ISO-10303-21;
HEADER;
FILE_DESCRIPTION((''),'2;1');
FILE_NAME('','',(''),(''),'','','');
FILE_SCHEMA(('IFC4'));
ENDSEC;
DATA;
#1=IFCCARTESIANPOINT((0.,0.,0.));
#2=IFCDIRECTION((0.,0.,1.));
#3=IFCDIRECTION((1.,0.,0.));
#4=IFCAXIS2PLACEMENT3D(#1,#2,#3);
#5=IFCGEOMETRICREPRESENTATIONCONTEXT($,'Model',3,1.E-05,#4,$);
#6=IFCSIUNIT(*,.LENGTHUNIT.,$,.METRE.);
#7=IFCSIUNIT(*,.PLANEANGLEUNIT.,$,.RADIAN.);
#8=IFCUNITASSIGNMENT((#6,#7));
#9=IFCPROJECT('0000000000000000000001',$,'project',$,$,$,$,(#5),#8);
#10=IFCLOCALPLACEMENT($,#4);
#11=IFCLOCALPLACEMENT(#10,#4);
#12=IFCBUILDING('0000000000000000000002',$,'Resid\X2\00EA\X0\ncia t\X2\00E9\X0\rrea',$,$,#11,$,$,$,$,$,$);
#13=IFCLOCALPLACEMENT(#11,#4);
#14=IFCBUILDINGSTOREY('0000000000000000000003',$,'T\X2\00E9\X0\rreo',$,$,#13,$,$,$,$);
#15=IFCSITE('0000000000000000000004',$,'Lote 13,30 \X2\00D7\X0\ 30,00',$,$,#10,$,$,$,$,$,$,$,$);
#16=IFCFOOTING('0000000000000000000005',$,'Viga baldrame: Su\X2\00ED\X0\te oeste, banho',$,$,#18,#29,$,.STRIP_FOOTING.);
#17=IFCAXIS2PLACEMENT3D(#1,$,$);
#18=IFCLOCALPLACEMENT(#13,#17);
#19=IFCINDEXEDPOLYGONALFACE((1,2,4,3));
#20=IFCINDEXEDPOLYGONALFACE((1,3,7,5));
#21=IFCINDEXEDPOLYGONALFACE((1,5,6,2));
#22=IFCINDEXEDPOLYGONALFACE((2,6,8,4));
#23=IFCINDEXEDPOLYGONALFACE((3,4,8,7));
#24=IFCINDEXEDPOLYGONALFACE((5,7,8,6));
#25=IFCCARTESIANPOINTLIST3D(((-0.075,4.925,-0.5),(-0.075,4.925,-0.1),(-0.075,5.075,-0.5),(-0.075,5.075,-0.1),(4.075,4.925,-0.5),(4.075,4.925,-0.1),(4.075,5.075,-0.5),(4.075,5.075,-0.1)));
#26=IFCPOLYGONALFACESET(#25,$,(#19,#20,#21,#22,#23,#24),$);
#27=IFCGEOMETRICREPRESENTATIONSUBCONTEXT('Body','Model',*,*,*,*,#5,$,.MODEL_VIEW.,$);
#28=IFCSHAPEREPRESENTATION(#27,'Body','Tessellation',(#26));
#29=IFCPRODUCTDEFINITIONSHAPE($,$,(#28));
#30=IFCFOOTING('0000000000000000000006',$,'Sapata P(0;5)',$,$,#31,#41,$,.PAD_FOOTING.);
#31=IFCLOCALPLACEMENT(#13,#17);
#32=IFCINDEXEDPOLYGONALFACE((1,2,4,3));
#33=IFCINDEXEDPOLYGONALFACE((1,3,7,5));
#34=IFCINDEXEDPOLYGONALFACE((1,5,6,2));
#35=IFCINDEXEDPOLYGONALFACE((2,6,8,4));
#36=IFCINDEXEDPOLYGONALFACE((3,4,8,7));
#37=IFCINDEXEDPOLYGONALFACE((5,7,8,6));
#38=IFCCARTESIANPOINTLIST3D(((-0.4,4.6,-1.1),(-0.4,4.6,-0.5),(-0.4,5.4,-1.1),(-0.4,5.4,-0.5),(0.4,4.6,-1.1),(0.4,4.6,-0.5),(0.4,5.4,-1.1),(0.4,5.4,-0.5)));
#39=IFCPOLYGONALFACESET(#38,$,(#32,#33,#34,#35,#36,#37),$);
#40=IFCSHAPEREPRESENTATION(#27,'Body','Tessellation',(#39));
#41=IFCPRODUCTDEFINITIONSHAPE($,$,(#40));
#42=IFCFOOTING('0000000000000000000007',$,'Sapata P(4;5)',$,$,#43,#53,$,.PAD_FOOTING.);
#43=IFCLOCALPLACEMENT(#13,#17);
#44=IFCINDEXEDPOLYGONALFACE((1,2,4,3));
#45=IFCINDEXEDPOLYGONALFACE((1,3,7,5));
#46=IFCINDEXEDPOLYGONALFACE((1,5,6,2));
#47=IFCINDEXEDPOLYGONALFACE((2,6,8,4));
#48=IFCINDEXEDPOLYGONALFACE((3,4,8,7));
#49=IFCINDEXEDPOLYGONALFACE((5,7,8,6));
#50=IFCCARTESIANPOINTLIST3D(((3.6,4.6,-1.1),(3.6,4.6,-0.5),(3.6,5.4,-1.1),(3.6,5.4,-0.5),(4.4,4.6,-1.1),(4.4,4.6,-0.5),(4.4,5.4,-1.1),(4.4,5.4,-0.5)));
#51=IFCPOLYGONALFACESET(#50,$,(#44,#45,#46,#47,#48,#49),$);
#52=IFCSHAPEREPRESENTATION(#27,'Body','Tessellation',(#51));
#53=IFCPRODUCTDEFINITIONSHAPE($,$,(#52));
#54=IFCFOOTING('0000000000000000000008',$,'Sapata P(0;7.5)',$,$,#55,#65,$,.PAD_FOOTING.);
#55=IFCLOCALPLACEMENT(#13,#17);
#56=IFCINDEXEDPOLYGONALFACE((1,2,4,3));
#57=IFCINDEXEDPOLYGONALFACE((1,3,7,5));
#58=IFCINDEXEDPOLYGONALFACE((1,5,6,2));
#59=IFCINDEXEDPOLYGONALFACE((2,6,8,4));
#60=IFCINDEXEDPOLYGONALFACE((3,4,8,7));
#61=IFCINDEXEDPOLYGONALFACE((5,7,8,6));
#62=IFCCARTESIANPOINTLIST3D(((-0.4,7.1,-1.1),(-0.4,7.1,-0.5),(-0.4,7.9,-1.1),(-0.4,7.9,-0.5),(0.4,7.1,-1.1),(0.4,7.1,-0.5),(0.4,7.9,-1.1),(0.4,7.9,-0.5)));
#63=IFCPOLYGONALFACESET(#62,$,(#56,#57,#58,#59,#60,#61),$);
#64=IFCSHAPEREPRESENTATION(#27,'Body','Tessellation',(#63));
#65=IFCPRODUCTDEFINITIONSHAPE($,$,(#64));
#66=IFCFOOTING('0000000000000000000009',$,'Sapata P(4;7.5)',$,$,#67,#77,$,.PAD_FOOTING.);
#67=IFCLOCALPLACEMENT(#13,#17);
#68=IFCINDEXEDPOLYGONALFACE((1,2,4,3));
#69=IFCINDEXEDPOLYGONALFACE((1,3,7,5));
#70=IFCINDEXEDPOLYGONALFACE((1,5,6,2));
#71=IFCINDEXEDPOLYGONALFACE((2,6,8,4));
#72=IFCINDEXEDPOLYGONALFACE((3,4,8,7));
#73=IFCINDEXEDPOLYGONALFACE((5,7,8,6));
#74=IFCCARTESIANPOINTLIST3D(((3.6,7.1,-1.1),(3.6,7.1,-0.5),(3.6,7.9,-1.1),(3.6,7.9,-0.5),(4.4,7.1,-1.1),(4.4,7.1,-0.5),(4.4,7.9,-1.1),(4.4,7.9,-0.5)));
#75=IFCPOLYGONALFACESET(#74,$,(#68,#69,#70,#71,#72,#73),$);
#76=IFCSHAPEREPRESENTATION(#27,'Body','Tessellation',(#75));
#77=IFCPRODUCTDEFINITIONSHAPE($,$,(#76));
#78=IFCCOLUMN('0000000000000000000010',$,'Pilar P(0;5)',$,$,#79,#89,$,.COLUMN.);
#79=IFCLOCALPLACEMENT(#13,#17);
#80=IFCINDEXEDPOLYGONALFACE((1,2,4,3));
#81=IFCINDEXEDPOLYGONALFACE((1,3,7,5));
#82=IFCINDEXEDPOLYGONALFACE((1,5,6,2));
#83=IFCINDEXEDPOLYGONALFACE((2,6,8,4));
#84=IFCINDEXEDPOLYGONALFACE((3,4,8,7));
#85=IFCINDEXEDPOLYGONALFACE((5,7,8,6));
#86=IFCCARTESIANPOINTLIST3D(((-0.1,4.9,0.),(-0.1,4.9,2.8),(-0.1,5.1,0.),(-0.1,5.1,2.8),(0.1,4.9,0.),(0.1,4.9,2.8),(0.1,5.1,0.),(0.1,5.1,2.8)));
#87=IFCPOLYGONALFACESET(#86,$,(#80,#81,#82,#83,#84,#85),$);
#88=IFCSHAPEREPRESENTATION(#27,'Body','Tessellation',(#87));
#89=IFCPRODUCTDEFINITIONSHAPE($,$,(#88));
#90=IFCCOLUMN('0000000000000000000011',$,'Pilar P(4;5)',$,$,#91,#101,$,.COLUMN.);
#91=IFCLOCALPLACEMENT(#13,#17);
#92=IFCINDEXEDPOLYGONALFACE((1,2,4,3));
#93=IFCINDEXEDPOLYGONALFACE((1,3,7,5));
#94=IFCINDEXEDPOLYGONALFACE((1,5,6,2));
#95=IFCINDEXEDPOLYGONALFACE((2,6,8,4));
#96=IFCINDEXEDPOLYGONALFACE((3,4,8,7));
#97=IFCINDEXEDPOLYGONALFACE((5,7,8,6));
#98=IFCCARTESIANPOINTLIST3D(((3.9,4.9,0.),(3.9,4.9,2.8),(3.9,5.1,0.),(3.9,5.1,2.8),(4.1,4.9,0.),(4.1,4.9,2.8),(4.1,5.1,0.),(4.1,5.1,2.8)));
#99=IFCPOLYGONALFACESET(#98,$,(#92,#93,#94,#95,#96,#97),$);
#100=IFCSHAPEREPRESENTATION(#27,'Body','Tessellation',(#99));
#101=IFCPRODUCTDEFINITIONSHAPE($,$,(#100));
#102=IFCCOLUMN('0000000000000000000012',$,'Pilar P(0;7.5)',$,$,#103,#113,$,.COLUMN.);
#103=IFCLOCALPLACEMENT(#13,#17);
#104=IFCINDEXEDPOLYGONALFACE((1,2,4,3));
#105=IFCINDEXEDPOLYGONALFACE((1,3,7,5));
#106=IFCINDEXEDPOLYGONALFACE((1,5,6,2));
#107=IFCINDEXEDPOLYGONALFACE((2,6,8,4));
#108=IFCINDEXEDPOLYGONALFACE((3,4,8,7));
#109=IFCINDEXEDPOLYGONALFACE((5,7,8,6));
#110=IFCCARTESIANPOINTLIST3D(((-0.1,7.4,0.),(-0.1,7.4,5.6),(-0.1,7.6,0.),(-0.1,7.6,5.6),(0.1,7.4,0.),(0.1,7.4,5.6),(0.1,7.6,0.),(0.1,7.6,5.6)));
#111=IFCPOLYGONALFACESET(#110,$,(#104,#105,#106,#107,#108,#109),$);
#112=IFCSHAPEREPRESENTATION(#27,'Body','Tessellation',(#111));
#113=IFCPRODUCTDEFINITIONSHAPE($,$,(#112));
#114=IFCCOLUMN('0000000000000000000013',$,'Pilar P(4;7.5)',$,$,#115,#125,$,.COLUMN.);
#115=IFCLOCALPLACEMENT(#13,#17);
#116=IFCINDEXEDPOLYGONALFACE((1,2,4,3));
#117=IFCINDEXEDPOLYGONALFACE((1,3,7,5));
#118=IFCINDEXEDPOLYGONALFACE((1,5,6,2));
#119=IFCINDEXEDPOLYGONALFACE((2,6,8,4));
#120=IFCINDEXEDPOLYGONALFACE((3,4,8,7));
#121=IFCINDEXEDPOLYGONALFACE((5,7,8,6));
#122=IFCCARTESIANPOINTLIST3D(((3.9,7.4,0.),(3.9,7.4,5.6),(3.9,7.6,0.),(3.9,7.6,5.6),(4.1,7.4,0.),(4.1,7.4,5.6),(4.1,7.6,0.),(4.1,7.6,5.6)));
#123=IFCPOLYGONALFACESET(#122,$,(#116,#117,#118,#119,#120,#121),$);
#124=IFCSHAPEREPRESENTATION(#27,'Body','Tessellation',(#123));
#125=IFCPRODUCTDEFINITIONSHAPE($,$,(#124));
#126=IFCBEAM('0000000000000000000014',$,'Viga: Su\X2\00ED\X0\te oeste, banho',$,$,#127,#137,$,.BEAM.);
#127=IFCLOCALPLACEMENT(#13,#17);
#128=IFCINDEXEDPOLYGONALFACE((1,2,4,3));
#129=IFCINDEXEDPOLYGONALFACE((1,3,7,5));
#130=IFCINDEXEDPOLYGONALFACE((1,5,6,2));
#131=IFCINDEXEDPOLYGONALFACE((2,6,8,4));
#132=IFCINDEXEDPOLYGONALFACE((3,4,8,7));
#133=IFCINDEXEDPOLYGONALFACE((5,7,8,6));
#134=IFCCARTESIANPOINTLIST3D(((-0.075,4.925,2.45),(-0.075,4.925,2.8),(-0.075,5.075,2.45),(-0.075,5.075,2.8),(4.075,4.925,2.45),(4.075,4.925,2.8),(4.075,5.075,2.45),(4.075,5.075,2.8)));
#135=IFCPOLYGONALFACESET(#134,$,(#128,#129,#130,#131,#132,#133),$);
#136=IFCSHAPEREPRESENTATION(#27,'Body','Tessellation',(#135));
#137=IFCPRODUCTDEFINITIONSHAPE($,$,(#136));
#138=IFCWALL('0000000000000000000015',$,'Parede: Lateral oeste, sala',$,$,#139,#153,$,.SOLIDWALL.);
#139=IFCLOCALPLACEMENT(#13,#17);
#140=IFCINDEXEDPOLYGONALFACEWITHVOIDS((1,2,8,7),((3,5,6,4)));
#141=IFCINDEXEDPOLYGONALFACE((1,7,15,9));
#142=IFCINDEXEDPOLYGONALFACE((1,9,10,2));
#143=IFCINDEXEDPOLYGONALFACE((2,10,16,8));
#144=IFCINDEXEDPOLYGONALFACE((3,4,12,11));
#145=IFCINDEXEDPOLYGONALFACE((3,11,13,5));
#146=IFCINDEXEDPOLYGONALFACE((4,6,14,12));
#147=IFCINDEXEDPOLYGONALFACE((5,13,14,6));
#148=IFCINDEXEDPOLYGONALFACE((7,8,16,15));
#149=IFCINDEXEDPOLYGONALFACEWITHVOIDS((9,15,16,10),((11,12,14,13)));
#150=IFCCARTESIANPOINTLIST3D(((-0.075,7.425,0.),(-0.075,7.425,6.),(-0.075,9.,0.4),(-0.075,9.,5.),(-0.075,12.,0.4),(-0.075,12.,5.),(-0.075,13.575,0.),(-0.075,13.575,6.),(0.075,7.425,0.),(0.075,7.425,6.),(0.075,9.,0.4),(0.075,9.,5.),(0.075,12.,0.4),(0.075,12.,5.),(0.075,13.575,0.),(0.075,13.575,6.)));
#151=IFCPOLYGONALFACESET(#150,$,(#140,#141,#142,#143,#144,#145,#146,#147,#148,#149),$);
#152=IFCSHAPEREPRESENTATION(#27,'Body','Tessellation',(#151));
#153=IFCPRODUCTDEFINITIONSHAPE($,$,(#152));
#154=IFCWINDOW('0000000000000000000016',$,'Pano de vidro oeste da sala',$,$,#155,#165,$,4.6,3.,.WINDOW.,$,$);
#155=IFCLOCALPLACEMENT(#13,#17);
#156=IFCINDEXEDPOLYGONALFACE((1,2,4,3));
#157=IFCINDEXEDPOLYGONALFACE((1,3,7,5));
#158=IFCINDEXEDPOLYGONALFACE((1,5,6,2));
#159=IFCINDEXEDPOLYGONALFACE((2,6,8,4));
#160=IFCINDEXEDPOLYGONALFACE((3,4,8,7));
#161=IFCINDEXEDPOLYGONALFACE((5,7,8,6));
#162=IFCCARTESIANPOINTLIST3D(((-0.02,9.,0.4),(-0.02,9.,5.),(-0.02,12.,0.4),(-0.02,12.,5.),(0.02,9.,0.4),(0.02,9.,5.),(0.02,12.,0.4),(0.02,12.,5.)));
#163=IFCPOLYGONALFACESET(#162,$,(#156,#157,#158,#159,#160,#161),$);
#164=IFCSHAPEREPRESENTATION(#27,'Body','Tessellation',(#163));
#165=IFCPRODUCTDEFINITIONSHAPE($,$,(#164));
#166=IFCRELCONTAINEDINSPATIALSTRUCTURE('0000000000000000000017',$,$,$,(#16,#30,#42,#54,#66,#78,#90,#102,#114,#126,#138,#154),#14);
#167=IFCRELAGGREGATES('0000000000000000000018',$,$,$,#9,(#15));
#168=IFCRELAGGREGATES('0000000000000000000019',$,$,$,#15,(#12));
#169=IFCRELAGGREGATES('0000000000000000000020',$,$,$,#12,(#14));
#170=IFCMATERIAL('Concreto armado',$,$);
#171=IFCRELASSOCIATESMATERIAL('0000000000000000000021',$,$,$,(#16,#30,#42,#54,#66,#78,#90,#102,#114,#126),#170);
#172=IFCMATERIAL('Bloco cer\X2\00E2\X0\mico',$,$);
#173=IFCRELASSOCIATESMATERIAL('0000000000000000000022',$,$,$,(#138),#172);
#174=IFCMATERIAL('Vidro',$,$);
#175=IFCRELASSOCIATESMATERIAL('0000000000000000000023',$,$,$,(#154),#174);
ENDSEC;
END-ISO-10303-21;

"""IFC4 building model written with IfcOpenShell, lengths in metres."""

from ifc_helpers import new_model, si_unit, frame, origin_with_axes, place, context, subcontext, project, spatial, line, indexed_curve, outline, extrude, material, element, fill, save


model = new_model("IFC4")

# Units and contexts
model_context = context("Model", 3, precision=1e-05, world=origin_with_axes())
body_context = subcontext(model_context, "Body", "Model", "MODEL_VIEW")
ifc_project = project(units=[si_unit("LENGTHUNIT", "METRE"), si_unit("PLANEANGLEUNIT", "RADIAN")], contexts=[model_context])

# Site, building, storey
site_placement = place(None, origin_with_axes())
site = spatial("IfcSite", under=ifc_project, at=site_placement, Name="Lote 13,30 × 30,00")
building_placement = place(site_placement, origin_with_axes())
building = spatial("IfcBuilding", under=site, at=building_placement, Name="Residência térrea")
storey_placement = place(building_placement, origin_with_axes())
storey = spatial("IfcBuildingStorey", under=building, at=storey_placement, Name="Térreo")

# Footings
ifc_material_1 = material(Name="Concreto armado")
footing_1_placement = place(storey_placement, frame((-0.075, 4.925, -0.5), z_axis=(0.0, 0.0, 1.0), x_axis=(1.0, 0.0, 0.0)))
element("IfcFooting", 1, at=footing_1_placement, inside=storey, material=ifc_material_1, Name="Viga baldrame: Suíte oeste, banho", PredefinedType="STRIP_FOOTING", context=body_context, shape_type="SweptSolid", body=[
    extrude(outline(indexed_curve([(0.0, 0.0), (4.15, 0.0), (4.15, 0.15), (0.0, 0.15)], segments=[line(1, 2, 3, 4, 1)])), origin_with_axes(), (0.0, 0.0, 1.0), 0.4),
])
footing_2_placement = place(storey_placement, frame((-0.4, 4.6, -1.1), z_axis=(0.0, 0.0, 1.0), x_axis=(1.0, 0.0, 0.0)))
element("IfcFooting", 2, at=footing_2_placement, inside=storey, material=ifc_material_1, Name="Sapata P(0;5)", PredefinedType="PAD_FOOTING", context=body_context, shape_type="SweptSolid", body=[
    extrude(outline(indexed_curve([(0.0, 0.0), (0.8, 0.0), (0.8, 0.8), (0.0, 0.8)], segments=[line(1, 2, 3, 4, 1)])), origin_with_axes(), (0.0, 0.0, 1.0), 0.6),
])
footing_3_placement = place(storey_placement, frame((3.6, 4.6, -1.1), z_axis=(0.0, 0.0, 1.0), x_axis=(1.0, 0.0, 0.0)))
element("IfcFooting", 3, at=footing_3_placement, inside=storey, material=ifc_material_1, Name="Sapata P(4;5)", PredefinedType="PAD_FOOTING", context=body_context, shape_type="SweptSolid", body=[
    extrude(outline(indexed_curve([(0.0, 0.0), (0.8, 0.0), (0.8, 0.8), (0.0, 0.8)], segments=[line(1, 2, 3, 4, 1)])), origin_with_axes(), (0.0, 0.0, 1.0), 0.6),
])
footing_4_placement = place(storey_placement, frame((-0.4, 7.1, -1.1), z_axis=(0.0, 0.0, 1.0), x_axis=(1.0, 0.0, 0.0)))
element("IfcFooting", 4, at=footing_4_placement, inside=storey, material=ifc_material_1, Name="Sapata P(0;7.5)", PredefinedType="PAD_FOOTING", context=body_context, shape_type="SweptSolid", body=[
    extrude(outline(indexed_curve([(0.0, 0.0), (0.8, 0.0), (0.8, 0.8), (0.0, 0.8)], segments=[line(1, 2, 3, 4, 1)])), origin_with_axes(), (0.0, 0.0, 1.0), 0.6),
])
footing_5_placement = place(storey_placement, frame((3.6, 7.1, -1.1), z_axis=(0.0, 0.0, 1.0), x_axis=(1.0, 0.0, 0.0)))
element("IfcFooting", 5, at=footing_5_placement, inside=storey, material=ifc_material_1, Name="Sapata P(4;7.5)", PredefinedType="PAD_FOOTING", context=body_context, shape_type="SweptSolid", body=[
    extrude(outline(indexed_curve([(0.0, 0.0), (0.8, 0.0), (0.8, 0.8), (0.0, 0.8)], segments=[line(1, 2, 3, 4, 1)])), origin_with_axes(), (0.0, 0.0, 1.0), 0.6),
])

# Columns
column_1_placement = place(storey_placement, frame((-0.1, 4.9, 0.0), z_axis=(0.0, 0.0, 1.0), x_axis=(1.0, 0.0, 0.0)))
element("IfcColumn", 6, at=column_1_placement, inside=storey, material=ifc_material_1, Name="Pilar P(0;5)", PredefinedType="COLUMN", context=body_context, shape_type="SweptSolid", body=[
    extrude(outline(indexed_curve([(0.0, 0.0), (0.2, 0.0), (0.2, 0.2), (0.0, 0.2)], segments=[line(1, 2, 3, 4, 1)])), origin_with_axes(), (0.0, 0.0, 1.0), 2.8),
])
column_2_placement = place(storey_placement, frame((3.9, 4.9, 0.0), z_axis=(0.0, 0.0, 1.0), x_axis=(1.0, 0.0, 0.0)))
element("IfcColumn", 7, at=column_2_placement, inside=storey, material=ifc_material_1, Name="Pilar P(4;5)", PredefinedType="COLUMN", context=body_context, shape_type="SweptSolid", body=[
    extrude(outline(indexed_curve([(0.0, 0.0), (0.2, 0.0), (0.2, 0.2), (0.0, 0.2)], segments=[line(1, 2, 3, 4, 1)])), origin_with_axes(), (0.0, 0.0, 1.0), 2.8),
])
column_3_placement = place(storey_placement, frame((-0.1, 7.4, 0.0), z_axis=(0.0, 0.0, 1.0), x_axis=(1.0, 0.0, 0.0)))
element("IfcColumn", 8, at=column_3_placement, inside=storey, material=ifc_material_1, Name="Pilar P(0;7.5)", PredefinedType="COLUMN", context=body_context, shape_type="SweptSolid", body=[
    extrude(outline(indexed_curve([(0.0, 0.0), (0.2, 0.0), (0.2, 0.2), (0.0, 0.2)], segments=[line(1, 2, 3, 4, 1)])), origin_with_axes(), (0.0, 0.0, 1.0), 5.6),
])
column_4_placement = place(storey_placement, frame((3.9, 7.4, 0.0), z_axis=(0.0, 0.0, 1.0), x_axis=(1.0, 0.0, 0.0)))
element("IfcColumn", 9, at=column_4_placement, inside=storey, material=ifc_material_1, Name="Pilar P(4;7.5)", PredefinedType="COLUMN", context=body_context, shape_type="SweptSolid", body=[
    extrude(outline(indexed_curve([(0.0, 0.0), (0.2, 0.0), (0.2, 0.2), (0.0, 0.2)], segments=[line(1, 2, 3, 4, 1)])), origin_with_axes(), (0.0, 0.0, 1.0), 5.6),
])

# Beam
beam_placement = place(storey_placement, frame((-0.075, 4.925, 2.45), z_axis=(0.0, 0.0, 1.0), x_axis=(1.0, 0.0, 0.0)))
element("IfcBeam", 10, at=beam_placement, inside=storey, material=ifc_material_1, Name="Viga: Suíte oeste, banho", PredefinedType="BEAM", context=body_context, shape_type="SweptSolid", body=[
    extrude(outline(indexed_curve([(0.0, 0.0), (4.15, 0.0), (4.15, 0.15), (0.0, 0.15)], segments=[line(1, 2, 3, 4, 1)])), origin_with_axes(), (0.0, 0.0, 1.0), 0.35),
])

# Wall, opening, window
ifc_material_2 = material(Name="Bloco cerâmico")
wall_1_placement = place(storey_placement, frame((-0.075, 7.425, 0.0), z_axis=(0.0, 0.0, 1.0), x_axis=(1.0, 0.0, 0.0)))
wall_1 = element("IfcWall", 11, at=wall_1_placement, inside=storey, material=ifc_material_2, Name="Parede: Lateral oeste, sala", PredefinedType="SOLIDWALL", context=body_context, shape_type="SweptSolid", body=[
    extrude(outline(indexed_curve([(0.0, 0.0), (0.15, 0.0), (0.15, 6.15), (0.0, 6.15)], segments=[line(1, 2, 3, 4, 1)])), origin_with_axes(), (0.0, 0.0, 1.0), 6.0),
])
opening_1_placement = place(wall_1_placement, frame((-0.05, 1.575, 0.4), z_axis=(0.0, 0.0, 1.0), x_axis=(1.0, 0.0, 0.0)))
opening_1 = element("IfcOpeningElement", 12, at=opening_1_placement, cuts=wall_1, material=ifc_material_1, PredefinedType="OPENING", context=body_context, shape_type="SweptSolid", body=[
    extrude(outline(indexed_curve([(0.0, 0.0), (0.25, 0.0), (0.25, 3.0), (0.0, 3.0)], segments=[line(1, 2, 3, 4, 1)])), origin_with_axes(), (0.0, 0.0, 1.0), 4.6),
])
ifc_material_3 = material(Name="Vidro")
window_placement = place(storey_placement, frame((-0.02, 9.0, 0.4), z_axis=(0.0, 0.0, 1.0), x_axis=(1.0, 0.0, 0.0)))
window = element("IfcWindow", 13, at=window_placement, inside=storey, material=ifc_material_3, Name="Pano de vidro oeste da sala", OverallHeight=4.6, OverallWidth=3.0, PredefinedType="WINDOW", context=body_context, shape_type="SweptSolid", body=[
    extrude(outline(indexed_curve([(0.0, 0.0), (0.04, 0.0), (0.04, 3.0), (0.0, 3.0)], segments=[line(1, 2, 3, 4, 1)])), origin_with_axes(), (0.0, 0.0, 1.0), 4.6),
])
fill(opening_1, window)

save(model, "model.ifc")
